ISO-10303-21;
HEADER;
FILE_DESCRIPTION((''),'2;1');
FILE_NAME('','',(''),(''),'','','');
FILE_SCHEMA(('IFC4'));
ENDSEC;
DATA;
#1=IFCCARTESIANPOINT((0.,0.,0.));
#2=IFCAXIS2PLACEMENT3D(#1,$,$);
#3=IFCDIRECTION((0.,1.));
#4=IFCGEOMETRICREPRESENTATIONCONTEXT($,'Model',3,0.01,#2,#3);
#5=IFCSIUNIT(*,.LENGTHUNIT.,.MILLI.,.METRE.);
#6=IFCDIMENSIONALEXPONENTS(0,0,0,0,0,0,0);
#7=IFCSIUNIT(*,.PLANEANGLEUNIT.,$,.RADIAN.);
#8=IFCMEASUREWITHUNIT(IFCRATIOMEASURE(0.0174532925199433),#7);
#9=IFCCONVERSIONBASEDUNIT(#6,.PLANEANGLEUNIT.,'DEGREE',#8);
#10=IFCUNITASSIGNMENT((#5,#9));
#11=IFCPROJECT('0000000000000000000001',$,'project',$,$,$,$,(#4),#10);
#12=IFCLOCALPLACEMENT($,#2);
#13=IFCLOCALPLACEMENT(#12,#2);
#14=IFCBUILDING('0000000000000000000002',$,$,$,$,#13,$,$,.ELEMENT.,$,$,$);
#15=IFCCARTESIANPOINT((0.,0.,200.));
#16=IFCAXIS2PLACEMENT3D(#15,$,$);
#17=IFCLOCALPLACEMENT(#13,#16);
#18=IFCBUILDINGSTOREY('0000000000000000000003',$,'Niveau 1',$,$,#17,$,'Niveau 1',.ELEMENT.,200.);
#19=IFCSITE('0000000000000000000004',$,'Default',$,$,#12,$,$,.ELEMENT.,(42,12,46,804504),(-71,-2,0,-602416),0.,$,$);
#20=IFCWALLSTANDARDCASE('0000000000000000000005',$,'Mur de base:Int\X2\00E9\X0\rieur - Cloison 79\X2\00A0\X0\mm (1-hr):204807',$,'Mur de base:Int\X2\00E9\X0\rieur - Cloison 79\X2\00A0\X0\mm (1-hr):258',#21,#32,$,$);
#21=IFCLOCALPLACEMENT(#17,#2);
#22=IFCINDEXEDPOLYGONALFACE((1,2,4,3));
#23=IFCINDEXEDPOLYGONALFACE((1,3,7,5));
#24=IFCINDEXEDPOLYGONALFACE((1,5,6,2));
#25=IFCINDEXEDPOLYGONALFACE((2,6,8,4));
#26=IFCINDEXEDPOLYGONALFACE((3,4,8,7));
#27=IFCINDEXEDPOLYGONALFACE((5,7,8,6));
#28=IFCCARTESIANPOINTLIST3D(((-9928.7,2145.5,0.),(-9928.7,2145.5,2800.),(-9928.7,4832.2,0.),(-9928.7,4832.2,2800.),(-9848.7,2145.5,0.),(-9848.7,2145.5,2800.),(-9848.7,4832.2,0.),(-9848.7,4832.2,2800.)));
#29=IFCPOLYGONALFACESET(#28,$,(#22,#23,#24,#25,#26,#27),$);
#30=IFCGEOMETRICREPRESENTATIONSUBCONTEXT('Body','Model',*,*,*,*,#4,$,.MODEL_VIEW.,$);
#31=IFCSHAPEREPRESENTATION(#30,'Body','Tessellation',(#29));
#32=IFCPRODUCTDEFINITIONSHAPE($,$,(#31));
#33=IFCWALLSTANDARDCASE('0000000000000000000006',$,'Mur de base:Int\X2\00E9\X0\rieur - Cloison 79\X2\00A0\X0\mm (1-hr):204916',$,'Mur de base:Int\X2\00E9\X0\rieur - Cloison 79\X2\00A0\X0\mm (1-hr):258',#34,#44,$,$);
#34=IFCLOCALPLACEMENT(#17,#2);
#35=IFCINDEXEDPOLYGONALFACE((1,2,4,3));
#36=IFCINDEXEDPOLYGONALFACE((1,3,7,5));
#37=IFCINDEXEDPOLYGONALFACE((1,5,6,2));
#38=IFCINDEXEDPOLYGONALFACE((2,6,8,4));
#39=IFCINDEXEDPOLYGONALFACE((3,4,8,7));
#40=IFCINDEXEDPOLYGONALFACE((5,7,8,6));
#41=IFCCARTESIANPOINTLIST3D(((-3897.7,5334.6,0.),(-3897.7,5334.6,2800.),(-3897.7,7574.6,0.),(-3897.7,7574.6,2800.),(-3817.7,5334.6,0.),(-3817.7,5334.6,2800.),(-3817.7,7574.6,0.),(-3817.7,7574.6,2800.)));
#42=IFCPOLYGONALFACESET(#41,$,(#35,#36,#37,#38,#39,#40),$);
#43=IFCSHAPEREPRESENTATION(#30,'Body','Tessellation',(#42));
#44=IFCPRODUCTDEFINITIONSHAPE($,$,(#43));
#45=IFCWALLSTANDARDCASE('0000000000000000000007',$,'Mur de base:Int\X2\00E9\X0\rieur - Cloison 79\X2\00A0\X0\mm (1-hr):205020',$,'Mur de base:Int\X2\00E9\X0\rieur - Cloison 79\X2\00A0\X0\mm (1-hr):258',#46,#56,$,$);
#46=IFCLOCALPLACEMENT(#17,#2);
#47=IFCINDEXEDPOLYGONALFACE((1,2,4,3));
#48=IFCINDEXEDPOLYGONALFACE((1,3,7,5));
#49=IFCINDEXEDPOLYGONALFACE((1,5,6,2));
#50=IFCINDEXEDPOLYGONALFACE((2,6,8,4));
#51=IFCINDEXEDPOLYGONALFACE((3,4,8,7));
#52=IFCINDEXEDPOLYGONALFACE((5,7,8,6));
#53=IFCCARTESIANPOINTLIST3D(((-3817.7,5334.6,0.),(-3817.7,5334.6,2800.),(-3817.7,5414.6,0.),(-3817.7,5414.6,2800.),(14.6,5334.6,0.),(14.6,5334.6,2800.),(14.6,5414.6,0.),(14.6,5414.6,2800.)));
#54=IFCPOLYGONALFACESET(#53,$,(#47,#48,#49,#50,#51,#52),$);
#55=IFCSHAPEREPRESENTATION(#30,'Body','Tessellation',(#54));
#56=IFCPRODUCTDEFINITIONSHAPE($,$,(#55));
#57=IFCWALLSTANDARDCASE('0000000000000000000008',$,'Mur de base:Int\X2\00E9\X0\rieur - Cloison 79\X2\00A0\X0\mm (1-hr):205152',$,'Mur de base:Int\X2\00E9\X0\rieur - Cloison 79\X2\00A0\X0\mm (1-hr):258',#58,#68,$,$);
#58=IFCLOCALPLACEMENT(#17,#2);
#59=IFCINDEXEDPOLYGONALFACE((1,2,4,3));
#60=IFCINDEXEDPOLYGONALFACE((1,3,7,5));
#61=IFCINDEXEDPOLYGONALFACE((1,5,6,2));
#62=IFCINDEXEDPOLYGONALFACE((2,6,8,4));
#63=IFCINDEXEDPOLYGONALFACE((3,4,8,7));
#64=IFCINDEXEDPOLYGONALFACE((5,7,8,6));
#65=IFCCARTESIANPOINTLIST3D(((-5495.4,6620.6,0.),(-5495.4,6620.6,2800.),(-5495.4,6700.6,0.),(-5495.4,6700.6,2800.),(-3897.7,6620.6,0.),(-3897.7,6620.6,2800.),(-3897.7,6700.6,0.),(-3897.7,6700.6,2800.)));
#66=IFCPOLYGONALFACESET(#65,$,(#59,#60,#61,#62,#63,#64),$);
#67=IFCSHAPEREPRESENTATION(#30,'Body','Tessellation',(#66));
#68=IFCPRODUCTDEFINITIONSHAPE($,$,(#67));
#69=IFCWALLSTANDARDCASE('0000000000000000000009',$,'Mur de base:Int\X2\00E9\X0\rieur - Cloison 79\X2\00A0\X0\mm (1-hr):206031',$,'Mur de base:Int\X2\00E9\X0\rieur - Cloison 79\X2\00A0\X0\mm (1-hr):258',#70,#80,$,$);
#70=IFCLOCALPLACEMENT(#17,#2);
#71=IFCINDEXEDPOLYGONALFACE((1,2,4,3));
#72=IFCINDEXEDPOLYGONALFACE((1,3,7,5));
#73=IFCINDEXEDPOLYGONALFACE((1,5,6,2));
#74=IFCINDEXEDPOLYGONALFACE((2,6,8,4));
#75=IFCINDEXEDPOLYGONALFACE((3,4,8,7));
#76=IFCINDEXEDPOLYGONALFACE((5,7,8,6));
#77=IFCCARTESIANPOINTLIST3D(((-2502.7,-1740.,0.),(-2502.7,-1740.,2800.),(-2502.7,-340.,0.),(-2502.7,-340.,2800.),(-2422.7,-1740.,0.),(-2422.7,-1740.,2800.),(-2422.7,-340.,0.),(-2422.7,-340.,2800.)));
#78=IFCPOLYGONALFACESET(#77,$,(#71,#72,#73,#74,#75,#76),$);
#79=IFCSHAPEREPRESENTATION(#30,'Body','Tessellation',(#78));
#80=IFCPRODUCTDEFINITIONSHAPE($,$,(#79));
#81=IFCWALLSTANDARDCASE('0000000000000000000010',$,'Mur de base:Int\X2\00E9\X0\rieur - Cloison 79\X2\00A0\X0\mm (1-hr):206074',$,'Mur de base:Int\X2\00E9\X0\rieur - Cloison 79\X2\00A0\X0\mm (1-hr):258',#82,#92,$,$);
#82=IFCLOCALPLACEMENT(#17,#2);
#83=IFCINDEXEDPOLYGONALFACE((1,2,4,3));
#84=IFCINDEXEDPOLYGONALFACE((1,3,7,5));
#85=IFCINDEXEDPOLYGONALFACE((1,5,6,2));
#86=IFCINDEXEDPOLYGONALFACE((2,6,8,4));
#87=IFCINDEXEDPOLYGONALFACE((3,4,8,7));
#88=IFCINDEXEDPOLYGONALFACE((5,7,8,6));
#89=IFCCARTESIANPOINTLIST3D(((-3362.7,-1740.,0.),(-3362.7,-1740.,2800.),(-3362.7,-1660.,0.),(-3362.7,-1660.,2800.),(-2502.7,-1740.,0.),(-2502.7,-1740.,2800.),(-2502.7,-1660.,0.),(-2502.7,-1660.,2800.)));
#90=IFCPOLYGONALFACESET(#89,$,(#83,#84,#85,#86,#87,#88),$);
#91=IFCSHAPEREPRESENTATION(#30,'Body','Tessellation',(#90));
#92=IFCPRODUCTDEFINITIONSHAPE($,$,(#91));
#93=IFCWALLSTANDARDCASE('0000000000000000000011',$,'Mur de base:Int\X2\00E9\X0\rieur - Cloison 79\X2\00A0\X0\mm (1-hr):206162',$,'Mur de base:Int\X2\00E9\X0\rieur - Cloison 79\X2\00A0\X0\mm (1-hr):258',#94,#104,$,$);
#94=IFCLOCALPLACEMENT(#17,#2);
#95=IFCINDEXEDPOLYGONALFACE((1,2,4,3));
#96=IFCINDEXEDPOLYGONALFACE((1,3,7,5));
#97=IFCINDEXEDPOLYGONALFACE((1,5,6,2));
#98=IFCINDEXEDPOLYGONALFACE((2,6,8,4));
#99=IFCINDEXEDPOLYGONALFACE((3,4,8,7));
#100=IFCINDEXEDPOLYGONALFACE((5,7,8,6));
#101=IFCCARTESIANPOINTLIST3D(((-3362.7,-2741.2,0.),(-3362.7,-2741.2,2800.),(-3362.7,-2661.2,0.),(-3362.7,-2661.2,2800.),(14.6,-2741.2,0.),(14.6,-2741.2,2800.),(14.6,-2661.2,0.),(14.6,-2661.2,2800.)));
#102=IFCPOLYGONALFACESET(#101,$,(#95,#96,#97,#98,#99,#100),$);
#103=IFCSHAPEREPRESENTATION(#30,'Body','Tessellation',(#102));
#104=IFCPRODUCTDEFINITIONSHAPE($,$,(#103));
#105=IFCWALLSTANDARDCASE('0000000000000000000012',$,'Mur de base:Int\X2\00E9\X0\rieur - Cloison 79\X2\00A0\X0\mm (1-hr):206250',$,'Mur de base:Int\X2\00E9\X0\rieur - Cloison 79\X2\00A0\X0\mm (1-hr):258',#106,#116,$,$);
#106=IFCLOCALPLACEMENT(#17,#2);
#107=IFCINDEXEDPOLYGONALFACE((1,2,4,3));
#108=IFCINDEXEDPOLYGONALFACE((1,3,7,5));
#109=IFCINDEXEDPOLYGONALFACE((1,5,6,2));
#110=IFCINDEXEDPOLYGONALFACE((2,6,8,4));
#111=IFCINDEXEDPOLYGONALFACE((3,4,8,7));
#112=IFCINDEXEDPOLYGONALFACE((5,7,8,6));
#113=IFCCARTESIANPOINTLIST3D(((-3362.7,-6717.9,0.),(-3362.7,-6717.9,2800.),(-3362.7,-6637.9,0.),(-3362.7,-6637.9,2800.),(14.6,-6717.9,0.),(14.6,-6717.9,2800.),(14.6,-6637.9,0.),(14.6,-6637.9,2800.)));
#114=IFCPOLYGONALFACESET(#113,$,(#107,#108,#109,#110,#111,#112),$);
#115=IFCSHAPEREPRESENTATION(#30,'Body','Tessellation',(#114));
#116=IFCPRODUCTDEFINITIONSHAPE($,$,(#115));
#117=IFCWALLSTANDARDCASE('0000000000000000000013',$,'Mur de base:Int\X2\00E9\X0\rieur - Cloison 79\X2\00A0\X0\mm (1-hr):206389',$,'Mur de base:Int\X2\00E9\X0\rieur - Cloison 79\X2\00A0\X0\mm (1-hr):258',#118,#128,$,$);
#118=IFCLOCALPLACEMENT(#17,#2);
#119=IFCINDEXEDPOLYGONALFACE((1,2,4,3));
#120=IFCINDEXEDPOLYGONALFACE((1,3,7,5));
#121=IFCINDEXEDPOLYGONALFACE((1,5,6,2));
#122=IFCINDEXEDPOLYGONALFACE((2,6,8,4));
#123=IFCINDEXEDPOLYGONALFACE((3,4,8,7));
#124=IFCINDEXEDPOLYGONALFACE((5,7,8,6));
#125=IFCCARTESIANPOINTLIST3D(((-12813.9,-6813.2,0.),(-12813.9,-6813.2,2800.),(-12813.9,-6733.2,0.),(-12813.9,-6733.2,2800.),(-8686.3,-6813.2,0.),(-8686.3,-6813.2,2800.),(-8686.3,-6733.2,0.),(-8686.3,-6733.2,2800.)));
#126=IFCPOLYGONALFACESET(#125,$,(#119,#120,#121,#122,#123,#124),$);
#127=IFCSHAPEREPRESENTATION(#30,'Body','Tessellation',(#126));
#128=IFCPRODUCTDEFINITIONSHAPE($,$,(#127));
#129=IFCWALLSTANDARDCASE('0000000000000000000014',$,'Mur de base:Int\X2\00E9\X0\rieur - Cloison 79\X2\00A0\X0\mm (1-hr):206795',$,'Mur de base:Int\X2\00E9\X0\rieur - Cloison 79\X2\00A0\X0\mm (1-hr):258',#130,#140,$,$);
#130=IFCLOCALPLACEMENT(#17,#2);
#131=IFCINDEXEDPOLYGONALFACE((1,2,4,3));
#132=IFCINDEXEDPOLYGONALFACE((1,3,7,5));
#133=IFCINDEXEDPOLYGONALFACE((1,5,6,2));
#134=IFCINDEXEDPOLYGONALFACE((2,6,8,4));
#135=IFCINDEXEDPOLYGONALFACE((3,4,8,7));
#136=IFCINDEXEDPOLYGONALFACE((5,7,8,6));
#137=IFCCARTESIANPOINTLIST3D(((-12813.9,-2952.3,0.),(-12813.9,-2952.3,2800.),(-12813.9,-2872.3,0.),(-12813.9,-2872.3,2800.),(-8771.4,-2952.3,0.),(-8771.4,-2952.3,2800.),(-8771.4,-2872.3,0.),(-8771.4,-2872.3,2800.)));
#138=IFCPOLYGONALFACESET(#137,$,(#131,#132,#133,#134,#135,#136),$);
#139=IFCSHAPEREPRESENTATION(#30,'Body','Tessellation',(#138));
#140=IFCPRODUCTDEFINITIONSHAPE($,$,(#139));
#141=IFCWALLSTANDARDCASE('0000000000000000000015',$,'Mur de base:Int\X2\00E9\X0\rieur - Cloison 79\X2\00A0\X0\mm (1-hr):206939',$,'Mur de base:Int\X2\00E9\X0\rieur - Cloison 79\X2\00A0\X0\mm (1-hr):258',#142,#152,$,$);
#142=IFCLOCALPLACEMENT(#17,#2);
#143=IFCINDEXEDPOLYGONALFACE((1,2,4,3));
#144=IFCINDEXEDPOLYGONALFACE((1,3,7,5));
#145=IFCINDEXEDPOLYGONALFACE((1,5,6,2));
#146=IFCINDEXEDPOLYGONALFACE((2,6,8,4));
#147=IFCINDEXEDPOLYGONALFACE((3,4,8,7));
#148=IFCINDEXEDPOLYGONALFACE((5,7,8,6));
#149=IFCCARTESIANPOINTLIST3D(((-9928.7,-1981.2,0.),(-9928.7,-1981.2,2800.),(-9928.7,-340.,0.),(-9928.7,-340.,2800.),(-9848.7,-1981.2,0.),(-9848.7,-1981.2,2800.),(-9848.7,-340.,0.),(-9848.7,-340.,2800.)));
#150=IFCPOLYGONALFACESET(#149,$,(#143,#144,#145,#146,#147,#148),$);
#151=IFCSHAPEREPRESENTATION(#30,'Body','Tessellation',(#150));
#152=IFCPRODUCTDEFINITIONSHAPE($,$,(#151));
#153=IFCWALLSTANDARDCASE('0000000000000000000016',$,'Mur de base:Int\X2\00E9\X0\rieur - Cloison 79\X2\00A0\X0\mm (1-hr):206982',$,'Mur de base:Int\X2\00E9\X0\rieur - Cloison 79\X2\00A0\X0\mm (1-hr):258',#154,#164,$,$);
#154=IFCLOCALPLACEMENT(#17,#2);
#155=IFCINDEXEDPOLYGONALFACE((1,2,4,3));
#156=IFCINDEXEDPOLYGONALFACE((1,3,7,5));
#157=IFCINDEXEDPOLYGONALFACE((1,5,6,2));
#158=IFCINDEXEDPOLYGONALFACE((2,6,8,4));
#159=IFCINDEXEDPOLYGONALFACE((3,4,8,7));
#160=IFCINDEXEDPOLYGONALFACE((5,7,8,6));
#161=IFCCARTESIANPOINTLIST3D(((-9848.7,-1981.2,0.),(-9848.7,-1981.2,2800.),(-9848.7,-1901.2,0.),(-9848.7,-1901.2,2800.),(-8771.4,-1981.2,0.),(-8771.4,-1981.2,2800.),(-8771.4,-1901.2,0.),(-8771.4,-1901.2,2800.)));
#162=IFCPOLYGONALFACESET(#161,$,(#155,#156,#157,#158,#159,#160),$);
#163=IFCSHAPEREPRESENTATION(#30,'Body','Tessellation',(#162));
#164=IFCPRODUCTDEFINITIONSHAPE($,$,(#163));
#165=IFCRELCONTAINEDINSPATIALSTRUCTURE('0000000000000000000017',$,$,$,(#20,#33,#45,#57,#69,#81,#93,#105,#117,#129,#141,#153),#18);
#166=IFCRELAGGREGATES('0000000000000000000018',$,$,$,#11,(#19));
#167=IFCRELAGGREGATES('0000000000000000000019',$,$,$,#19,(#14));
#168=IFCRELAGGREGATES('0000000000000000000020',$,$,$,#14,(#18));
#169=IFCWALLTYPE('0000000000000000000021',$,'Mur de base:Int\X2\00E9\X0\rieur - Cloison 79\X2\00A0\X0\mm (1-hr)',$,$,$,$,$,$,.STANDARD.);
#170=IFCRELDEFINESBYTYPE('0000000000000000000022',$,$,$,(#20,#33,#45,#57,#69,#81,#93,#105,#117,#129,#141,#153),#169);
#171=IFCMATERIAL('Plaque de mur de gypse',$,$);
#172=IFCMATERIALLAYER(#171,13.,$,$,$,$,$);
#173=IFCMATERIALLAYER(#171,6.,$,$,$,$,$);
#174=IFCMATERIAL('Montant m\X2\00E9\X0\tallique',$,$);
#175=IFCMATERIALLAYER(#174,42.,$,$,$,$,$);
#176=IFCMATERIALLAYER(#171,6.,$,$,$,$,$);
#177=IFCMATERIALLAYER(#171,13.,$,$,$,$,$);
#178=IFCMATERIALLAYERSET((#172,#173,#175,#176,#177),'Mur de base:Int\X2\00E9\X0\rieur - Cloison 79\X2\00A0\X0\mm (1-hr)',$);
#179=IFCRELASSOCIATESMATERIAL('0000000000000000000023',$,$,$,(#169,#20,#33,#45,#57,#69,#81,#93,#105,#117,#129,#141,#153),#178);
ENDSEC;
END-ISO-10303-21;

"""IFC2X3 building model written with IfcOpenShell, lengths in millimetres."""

from ifc_helpers import new_model, entity, si_unit, converted_unit, direction, frame, frame_2d, origin, place, context, subcontext, project, spatial, polyline, rectangle, extrude, clip, bounded_halfspace, material, layer, layer_set, layer_usage, type_object, element, save


model = new_model("IFC2X3")

# Units and contexts
model_context = context("Model", 3, precision=0.01, world=origin(), true_north=direction((0.0, 1.0)))
body_context = subcontext(model_context, "Body", "Model", "MODEL_VIEW")
ifc_project = project(units=[si_unit("LENGTHUNIT", "METRE", prefix="MILLI"), converted_unit("PLANEANGLEUNIT", "DEGREE", entity("IfcRatioMeasure", 0.0174532925199433), si_unit("PLANEANGLEUNIT", "RADIAN"), dimensions=[0, 0, 0, 0, 0, 0, 0])], contexts=[model_context])

# Site, building, storey
site_placement = place(None, origin())
site = spatial("IfcSite", under=ifc_project, at=site_placement, Name="Default", CompositionType="ELEMENT", RefLatitude=(42, 12, 46, 804504), RefLongitude=(-71, -2, 0, -602416), RefElevation=0.0)
building_placement = place(site_placement, origin())
building = spatial("IfcBuilding", under=site, at=building_placement, CompositionType="ELEMENT")
storey_placement = place(building_placement, frame((0.0, 0.0, 200.0)))
storey = spatial("IfcBuildingStorey", under=building, at=storey_placement, Name="Niveau 1", LongName="Niveau 1", CompositionType="ELEMENT", Elevation=200.0)

# Walls
ifc_material_1 = material(Name="Plaque de mur de gypse")
ifc_layer_1 = layer(ifc_material_1, 13.0)
ifc_layer_2 = layer(ifc_material_1, 6.0)
ifc_material_2 = material(Name="Montant métallique")
ifc_layer_3 = layer(ifc_material_2, 42.0)
ifc_layer_4 = layer(ifc_material_1, 6.0)
ifc_layer_5 = layer(ifc_material_1, 13.0)
ifc_layer_set_1 = layer_set([ifc_layer_1, ifc_layer_2, ifc_layer_3, ifc_layer_4, ifc_layer_5], Name="Mur de base:Intérieur - Cloison 79 mm (1-hr)")
wall_type_1 = type_object("IfcWallType", Name="Mur de base:Intérieur - Cloison 79 mm (1-hr)", PredefinedType="STANDARD", material=ifc_layer_set_1)
ifc_layer_usage_1 = layer_usage(ifc_layer_set_1, "AXIS2", "NEGATIVE", 40.0)
wall_1_placement = place(storey_placement, frame((-9888.7, 4832.2, 0.0), z_axis=(0.0, 0.0, 1.0), x_axis=(0.0, -1.0, 0.0)))
element("IfcWallStandardCase", 1, at=wall_1_placement, inside=storey, type_object=wall_type_1, material=ifc_layer_usage_1, Name="Mur de base:Intérieur - Cloison 79 mm (1-hr):204807", ObjectType="Mur de base:Intérieur - Cloison 79 mm (1-hr):258", context=body_context, shape_type="Clipping", body=[
    clip(extrude(rectangle(XDim=2686.6, YDim=80.0, at=frame_2d((1343.3, 0.0), x_axis=(-1.0, 0.0))), origin(), (0.0, 0.0, 1.0), 2800.0), bounded_halfspace(frame((0.0, -40.0, 2800.0), z_axis=(0.0, 0.0, -1.0), x_axis=(-1.0, 0.0, 0.0)), True, frame((0.0, -40.0, 2800.0)), polyline([(0.0, 0.0), (2686.6, 0.0), (2686.6, 80.0), (0.0, 80.0), (0.0, 0.0)]))),
])
ifc_layer_usage_2 = layer_usage(ifc_layer_set_1, "AXIS2", "NEGATIVE", 40.0)
wall_2_placement = place(storey_placement, frame((-3857.7, 7574.6, 0.0), z_axis=(0.0, 0.0, 1.0), x_axis=(0.0, -1.0, 0.0)))
element("IfcWallStandardCase", 2, at=wall_2_placement, inside=storey, type_object=wall_type_1, material=ifc_layer_usage_2, Name="Mur de base:Intérieur - Cloison 79 mm (1-hr):204916", ObjectType="Mur de base:Intérieur - Cloison 79 mm (1-hr):258", context=body_context, shape_type="Clipping", body=[
    clip(extrude(rectangle(XDim=2240.0, YDim=80.0, at=frame_2d((1120.0, 0.0), x_axis=(-1.0, 0.0))), origin(), (0.0, 0.0, 1.0), 2800.0), bounded_halfspace(frame((0.0, -40.0, 2800.0), z_axis=(0.0, 0.0, -1.0), x_axis=(-1.0, 0.0, 0.0)), True, frame((0.0, -40.0, 2800.0)), polyline([(0.0, 0.0), (873.9, 0.0), (953.9, 0.0), (2240.0, 0.0), (2240.0, 80.0), (2160.0, 80.0), (0.0, 80.0), (0.0, 0.0)]))),
])
ifc_layer_usage_3 = layer_usage(ifc_layer_set_1, "AXIS2", "NEGATIVE", 40.0)
wall_3_placement = place(storey_placement, frame((-3817.7, 5374.6, 0.0)))
element("IfcWallStandardCase", 3, at=wall_3_placement, inside=storey, type_object=wall_type_1, material=ifc_layer_usage_3, Name="Mur de base:Intérieur - Cloison 79 mm (1-hr):205020", ObjectType="Mur de base:Intérieur - Cloison 79 mm (1-hr):258", context=body_context, shape_type="Clipping", body=[
    clip(extrude(rectangle(XDim=3832.3, YDim=80.0, at=frame_2d((1916.1, 0.0), x_axis=(-1.0, 0.0))), origin(), (0.0, 0.0, 1.0), 2800.0), bounded_halfspace(frame((0.0, -40.0, 2800.0), z_axis=(0.0, 0.0, -1.0), x_axis=(0.0, 1.0, 0.0)), True, frame((0.0, -40.0, 2800.0)), polyline([(0.0, 0.0), (375.0, 0.0), (455.0, 0.0), (3832.3, 0.0), (3832.3, 80.0), (0.0, 80.0), (0.0, 0.0)]))),
])
ifc_layer_usage_4 = layer_usage(ifc_layer_set_1, "AXIS2", "NEGATIVE", 40.0)
wall_4_placement = place(storey_placement, frame((-5495.4, 6660.6, 0.0)))
element("IfcWallStandardCase", 4, at=wall_4_placement, inside=storey, type_object=wall_type_1, material=ifc_layer_usage_4, Name="Mur de base:Intérieur - Cloison 79 mm (1-hr):205152", ObjectType="Mur de base:Intérieur - Cloison 79 mm (1-hr):258", context=body_context, shape_type="Clipping", body=[
    clip(extrude(rectangle(XDim=1597.7, YDim=80.0, at=frame_2d((798.9, 0.0), x_axis=(-1.0, 0.0))), origin(), (0.0, 0.0, 1.0), 2800.0), bounded_halfspace(frame((0.0, -40.0, 2800.0), z_axis=(0.0, 0.0, -1.0), x_axis=(0.0, 1.0, 0.0)), True, frame((0.0, -40.0, 2800.0)), polyline([(0.0, 0.0), (1597.7, 0.0), (1597.7, 80.0), (0.0, 80.0), (0.0, 0.0)]))),
])
ifc_layer_usage_5 = layer_usage(ifc_layer_set_1, "AXIS2", "NEGATIVE", 40.0)
wall_5_placement = place(storey_placement, frame((-2462.7, -340.0, 0.0), z_axis=(0.0, 0.0, 1.0), x_axis=(0.0, -1.0, 0.0)))
element("IfcWallStandardCase", 5, at=wall_5_placement, inside=storey, type_object=wall_type_1, material=ifc_layer_usage_5, Name="Mur de base:Intérieur - Cloison 79 mm (1-hr):206031", ObjectType="Mur de base:Intérieur - Cloison 79 mm (1-hr):258", context=body_context, shape_type="Clipping", body=[
    clip(extrude(rectangle(XDim=1400.0, YDim=80.0, at=frame_2d((700.0, 0.0), x_axis=(-1.0, 0.0))), origin(), (0.0, 0.0, 1.0), 2800.0), bounded_halfspace(frame((0.0, -40.0, 2800.0), z_axis=(0.0, 0.0, -1.0), x_axis=(-1.0, 0.0, 0.0)), True, frame((0.0, -40.0, 2800.0)), polyline([(0.0, 0.0), (1320.0, 0.0), (1400.0, 0.0), (1400.0, 80.0), (0.0, 80.0), (0.0, 0.0)]))),
])
ifc_layer_usage_6 = layer_usage(ifc_layer_set_1, "AXIS2", "NEGATIVE", 40.0)
wall_6_placement = place(storey_placement, frame((-2502.7, -1700.0, 0.0), z_axis=(0.0, 0.0, 1.0), x_axis=(-1.0, 0.0, 0.0)))
element("IfcWallStandardCase", 6, at=wall_6_placement, inside=storey, type_object=wall_type_1, material=ifc_layer_usage_6, Name="Mur de base:Intérieur - Cloison 79 mm (1-hr):206074", ObjectType="Mur de base:Intérieur - Cloison 79 mm (1-hr):258", context=body_context, shape_type="Clipping", body=[
    clip(extrude(rectangle(XDim=860.0, YDim=80.0, at=frame_2d((430.0, 0.0), x_axis=(-1.0, 0.0))), origin(), (0.0, 0.0, 1.0), 2800.0), bounded_halfspace(frame((0.0, -40.0, 2800.0), z_axis=(0.0, 0.0, -1.0), x_axis=(0.0, -1.0, 0.0)), True, frame((0.0, -40.0, 2800.0)), polyline([(0.0, 0.0), (860.0, 0.0), (860.0, 80.0), (0.0, 80.0), (0.0, 0.0)]))),
])
ifc_layer_usage_7 = layer_usage(ifc_layer_set_1, "AXIS2", "NEGATIVE", 40.0)
wall_7_placement = place(storey_placement, frame((-3362.7, -2701.2, 0.0)))
element("IfcWallStandardCase", 7, at=wall_7_placement, inside=storey, type_object=wall_type_1, material=ifc_layer_usage_7, Name="Mur de base:Intérieur - Cloison 79 mm (1-hr):206162", ObjectType="Mur de base:Intérieur - Cloison 79 mm (1-hr):258", context=body_context, shape_type="Clipping", body=[
    clip(extrude(rectangle(XDim=3377.3, YDim=80.0, at=frame_2d((1688.6, 0.0), x_axis=(-1.0, 0.0))), origin(), (0.0, 0.0, 1.0), 2800.0), bounded_halfspace(frame((0.0, -40.0, 2800.0), z_axis=(0.0, 0.0, -1.0), x_axis=(0.0, 1.0, 0.0)), True, frame((0.0, -40.0, 2800.0)), polyline([(0.0, 0.0), (3377.3, 0.0), (3377.3, 80.0), (0.0, 80.0), (0.0, 0.0)]))),
])
ifc_layer_usage_8 = layer_usage(ifc_layer_set_1, "AXIS2", "NEGATIVE", 40.0)
wall_8_placement = place(storey_placement, frame((-3362.7, -6677.9, 0.0)))
element("IfcWallStandardCase", 8, at=wall_8_placement, inside=storey, type_object=wall_type_1, material=ifc_layer_usage_8, Name="Mur de base:Intérieur - Cloison 79 mm (1-hr):206250", ObjectType="Mur de base:Intérieur - Cloison 79 mm (1-hr):258", context=body_context, shape_type="Clipping", body=[
    clip(extrude(rectangle(XDim=3377.3, YDim=80.0, at=frame_2d((1688.6, 0.0), x_axis=(-1.0, 0.0))), origin(), (0.0, 0.0, 1.0), 2800.0), bounded_halfspace(frame((0.0, -40.0, 2800.0), z_axis=(0.0, 0.0, -1.0), x_axis=(0.0, 1.0, 0.0)), True, frame((0.0, -40.0, 2800.0)), polyline([(0.0, 0.0), (3377.3, 0.0), (3377.3, 80.0), (0.0, 80.0), (0.0, 0.0)]))),
])
ifc_layer_usage_9 = layer_usage(ifc_layer_set_1, "AXIS2", "NEGATIVE", 40.0)
wall_9_placement = place(storey_placement, frame((-12813.9, -6773.2, 0.0)))
element("IfcWallStandardCase", 9, at=wall_9_placement, inside=storey, type_object=wall_type_1, material=ifc_layer_usage_9, Name="Mur de base:Intérieur - Cloison 79 mm (1-hr):206389", ObjectType="Mur de base:Intérieur - Cloison 79 mm (1-hr):258", context=body_context, shape_type="Clipping", body=[
    clip(extrude(rectangle(XDim=4127.7, YDim=80.0, at=frame_2d((2063.8, 0.0), x_axis=(-1.0, 0.0))), origin(), (0.0, 0.0, 1.0), 2800.0), bounded_halfspace(frame((0.0, -40.0, 2800.0), z_axis=(0.0, 0.0, -1.0), x_axis=(0.0, 1.0, 0.0)), True, frame((0.0, -40.0, 2800.0)), polyline([(0.0, 0.0), (4127.7, 0.0), (4127.7, 80.0), (0.0, 80.0), (0.0, 0.0)]))),
])
ifc_layer_usage_10 = layer_usage(ifc_layer_set_1, "AXIS2", "NEGATIVE", 40.0)
wall_10_placement = place(storey_placement, frame((-12813.9, -2912.3, 0.0)))
element("IfcWallStandardCase", 10, at=wall_10_placement, inside=storey, type_object=wall_type_1, material=ifc_layer_usage_10, Name="Mur de base:Intérieur - Cloison 79 mm (1-hr):206795", ObjectType="Mur de base:Intérieur - Cloison 79 mm (1-hr):258", context=body_context, shape_type="Clipping", body=[
    clip(extrude(rectangle(XDim=4042.6, YDim=80.0, at=frame_2d((2021.3, 0.0), x_axis=(-1.0, 0.0))), origin(), (0.0, 0.0, 1.0), 2800.0), bounded_halfspace(frame((0.0, -40.0, 2800.0), z_axis=(0.0, 0.0, -1.0), x_axis=(0.0, 1.0, 0.0)), True, frame((0.0, -40.0, 2800.0)), polyline([(0.0, 0.0), (4042.6, 0.0), (4042.6, 80.0), (0.0, 80.0), (0.0, 0.0)]))),
])
ifc_layer_usage_11 = layer_usage(ifc_layer_set_1, "AXIS2", "NEGATIVE", 40.0)
wall_11_placement = place(storey_placement, frame((-9888.7, -340.0, 0.0), z_axis=(0.0, 0.0, 1.0), x_axis=(0.0, -1.0, 0.0)))
element("IfcWallStandardCase", 11, at=wall_11_placement, inside=storey, type_object=wall_type_1, material=ifc_layer_usage_11, Name="Mur de base:Intérieur - Cloison 79 mm (1-hr):206939", ObjectType="Mur de base:Intérieur - Cloison 79 mm (1-hr):258", context=body_context, shape_type="Clipping", body=[
    clip(extrude(rectangle(XDim=1641.2, YDim=80.0, at=frame_2d((820.6, 0.0), x_axis=(-1.0, 0.0))), origin(), (0.0, 0.0, 1.0), 2800.0), bounded_halfspace(frame((0.0, -40.0, 2800.0), z_axis=(0.0, 0.0, -1.0), x_axis=(-1.0, 0.0, 0.0)), True, frame((0.0, -40.0, 2800.0)), polyline([(0.0, 0.0), (1641.2, 0.0), (1641.2, 80.0), (1561.2, 80.0), (0.0, 80.0), (0.0, 0.0)]))),
])
ifc_layer_usage_12 = layer_usage(ifc_layer_set_1, "AXIS2", "NEGATIVE", 40.0)
wall_12_placement = place(storey_placement, frame((-9848.7, -1941.2, 0.0)))
element("IfcWallStandardCase", 12, at=wall_12_placement, inside=storey, type_object=wall_type_1, material=ifc_layer_usage_12, Name="Mur de base:Intérieur - Cloison 79 mm (1-hr):206982", ObjectType="Mur de base:Intérieur - Cloison 79 mm (1-hr):258", context=body_context, shape_type="Clipping", body=[
    clip(extrude(rectangle(XDim=1077.3, YDim=80.0, at=frame_2d((538.7, 0.0), x_axis=(-1.0, 0.0))), origin(), (0.0, 0.0, 1.0), 2800.0), bounded_halfspace(frame((0.0, -40.0, 2800.0), z_axis=(0.0, 0.0, -1.0), x_axis=(0.0, 1.0, 0.0)), True, frame((0.0, -40.0, 2800.0)), polyline([(0.0, 0.0), (1077.3, 0.0), (1077.3, 80.0), (0.0, 80.0), (0.0, 0.0)]))),
])

save(model, "model.ifc")
